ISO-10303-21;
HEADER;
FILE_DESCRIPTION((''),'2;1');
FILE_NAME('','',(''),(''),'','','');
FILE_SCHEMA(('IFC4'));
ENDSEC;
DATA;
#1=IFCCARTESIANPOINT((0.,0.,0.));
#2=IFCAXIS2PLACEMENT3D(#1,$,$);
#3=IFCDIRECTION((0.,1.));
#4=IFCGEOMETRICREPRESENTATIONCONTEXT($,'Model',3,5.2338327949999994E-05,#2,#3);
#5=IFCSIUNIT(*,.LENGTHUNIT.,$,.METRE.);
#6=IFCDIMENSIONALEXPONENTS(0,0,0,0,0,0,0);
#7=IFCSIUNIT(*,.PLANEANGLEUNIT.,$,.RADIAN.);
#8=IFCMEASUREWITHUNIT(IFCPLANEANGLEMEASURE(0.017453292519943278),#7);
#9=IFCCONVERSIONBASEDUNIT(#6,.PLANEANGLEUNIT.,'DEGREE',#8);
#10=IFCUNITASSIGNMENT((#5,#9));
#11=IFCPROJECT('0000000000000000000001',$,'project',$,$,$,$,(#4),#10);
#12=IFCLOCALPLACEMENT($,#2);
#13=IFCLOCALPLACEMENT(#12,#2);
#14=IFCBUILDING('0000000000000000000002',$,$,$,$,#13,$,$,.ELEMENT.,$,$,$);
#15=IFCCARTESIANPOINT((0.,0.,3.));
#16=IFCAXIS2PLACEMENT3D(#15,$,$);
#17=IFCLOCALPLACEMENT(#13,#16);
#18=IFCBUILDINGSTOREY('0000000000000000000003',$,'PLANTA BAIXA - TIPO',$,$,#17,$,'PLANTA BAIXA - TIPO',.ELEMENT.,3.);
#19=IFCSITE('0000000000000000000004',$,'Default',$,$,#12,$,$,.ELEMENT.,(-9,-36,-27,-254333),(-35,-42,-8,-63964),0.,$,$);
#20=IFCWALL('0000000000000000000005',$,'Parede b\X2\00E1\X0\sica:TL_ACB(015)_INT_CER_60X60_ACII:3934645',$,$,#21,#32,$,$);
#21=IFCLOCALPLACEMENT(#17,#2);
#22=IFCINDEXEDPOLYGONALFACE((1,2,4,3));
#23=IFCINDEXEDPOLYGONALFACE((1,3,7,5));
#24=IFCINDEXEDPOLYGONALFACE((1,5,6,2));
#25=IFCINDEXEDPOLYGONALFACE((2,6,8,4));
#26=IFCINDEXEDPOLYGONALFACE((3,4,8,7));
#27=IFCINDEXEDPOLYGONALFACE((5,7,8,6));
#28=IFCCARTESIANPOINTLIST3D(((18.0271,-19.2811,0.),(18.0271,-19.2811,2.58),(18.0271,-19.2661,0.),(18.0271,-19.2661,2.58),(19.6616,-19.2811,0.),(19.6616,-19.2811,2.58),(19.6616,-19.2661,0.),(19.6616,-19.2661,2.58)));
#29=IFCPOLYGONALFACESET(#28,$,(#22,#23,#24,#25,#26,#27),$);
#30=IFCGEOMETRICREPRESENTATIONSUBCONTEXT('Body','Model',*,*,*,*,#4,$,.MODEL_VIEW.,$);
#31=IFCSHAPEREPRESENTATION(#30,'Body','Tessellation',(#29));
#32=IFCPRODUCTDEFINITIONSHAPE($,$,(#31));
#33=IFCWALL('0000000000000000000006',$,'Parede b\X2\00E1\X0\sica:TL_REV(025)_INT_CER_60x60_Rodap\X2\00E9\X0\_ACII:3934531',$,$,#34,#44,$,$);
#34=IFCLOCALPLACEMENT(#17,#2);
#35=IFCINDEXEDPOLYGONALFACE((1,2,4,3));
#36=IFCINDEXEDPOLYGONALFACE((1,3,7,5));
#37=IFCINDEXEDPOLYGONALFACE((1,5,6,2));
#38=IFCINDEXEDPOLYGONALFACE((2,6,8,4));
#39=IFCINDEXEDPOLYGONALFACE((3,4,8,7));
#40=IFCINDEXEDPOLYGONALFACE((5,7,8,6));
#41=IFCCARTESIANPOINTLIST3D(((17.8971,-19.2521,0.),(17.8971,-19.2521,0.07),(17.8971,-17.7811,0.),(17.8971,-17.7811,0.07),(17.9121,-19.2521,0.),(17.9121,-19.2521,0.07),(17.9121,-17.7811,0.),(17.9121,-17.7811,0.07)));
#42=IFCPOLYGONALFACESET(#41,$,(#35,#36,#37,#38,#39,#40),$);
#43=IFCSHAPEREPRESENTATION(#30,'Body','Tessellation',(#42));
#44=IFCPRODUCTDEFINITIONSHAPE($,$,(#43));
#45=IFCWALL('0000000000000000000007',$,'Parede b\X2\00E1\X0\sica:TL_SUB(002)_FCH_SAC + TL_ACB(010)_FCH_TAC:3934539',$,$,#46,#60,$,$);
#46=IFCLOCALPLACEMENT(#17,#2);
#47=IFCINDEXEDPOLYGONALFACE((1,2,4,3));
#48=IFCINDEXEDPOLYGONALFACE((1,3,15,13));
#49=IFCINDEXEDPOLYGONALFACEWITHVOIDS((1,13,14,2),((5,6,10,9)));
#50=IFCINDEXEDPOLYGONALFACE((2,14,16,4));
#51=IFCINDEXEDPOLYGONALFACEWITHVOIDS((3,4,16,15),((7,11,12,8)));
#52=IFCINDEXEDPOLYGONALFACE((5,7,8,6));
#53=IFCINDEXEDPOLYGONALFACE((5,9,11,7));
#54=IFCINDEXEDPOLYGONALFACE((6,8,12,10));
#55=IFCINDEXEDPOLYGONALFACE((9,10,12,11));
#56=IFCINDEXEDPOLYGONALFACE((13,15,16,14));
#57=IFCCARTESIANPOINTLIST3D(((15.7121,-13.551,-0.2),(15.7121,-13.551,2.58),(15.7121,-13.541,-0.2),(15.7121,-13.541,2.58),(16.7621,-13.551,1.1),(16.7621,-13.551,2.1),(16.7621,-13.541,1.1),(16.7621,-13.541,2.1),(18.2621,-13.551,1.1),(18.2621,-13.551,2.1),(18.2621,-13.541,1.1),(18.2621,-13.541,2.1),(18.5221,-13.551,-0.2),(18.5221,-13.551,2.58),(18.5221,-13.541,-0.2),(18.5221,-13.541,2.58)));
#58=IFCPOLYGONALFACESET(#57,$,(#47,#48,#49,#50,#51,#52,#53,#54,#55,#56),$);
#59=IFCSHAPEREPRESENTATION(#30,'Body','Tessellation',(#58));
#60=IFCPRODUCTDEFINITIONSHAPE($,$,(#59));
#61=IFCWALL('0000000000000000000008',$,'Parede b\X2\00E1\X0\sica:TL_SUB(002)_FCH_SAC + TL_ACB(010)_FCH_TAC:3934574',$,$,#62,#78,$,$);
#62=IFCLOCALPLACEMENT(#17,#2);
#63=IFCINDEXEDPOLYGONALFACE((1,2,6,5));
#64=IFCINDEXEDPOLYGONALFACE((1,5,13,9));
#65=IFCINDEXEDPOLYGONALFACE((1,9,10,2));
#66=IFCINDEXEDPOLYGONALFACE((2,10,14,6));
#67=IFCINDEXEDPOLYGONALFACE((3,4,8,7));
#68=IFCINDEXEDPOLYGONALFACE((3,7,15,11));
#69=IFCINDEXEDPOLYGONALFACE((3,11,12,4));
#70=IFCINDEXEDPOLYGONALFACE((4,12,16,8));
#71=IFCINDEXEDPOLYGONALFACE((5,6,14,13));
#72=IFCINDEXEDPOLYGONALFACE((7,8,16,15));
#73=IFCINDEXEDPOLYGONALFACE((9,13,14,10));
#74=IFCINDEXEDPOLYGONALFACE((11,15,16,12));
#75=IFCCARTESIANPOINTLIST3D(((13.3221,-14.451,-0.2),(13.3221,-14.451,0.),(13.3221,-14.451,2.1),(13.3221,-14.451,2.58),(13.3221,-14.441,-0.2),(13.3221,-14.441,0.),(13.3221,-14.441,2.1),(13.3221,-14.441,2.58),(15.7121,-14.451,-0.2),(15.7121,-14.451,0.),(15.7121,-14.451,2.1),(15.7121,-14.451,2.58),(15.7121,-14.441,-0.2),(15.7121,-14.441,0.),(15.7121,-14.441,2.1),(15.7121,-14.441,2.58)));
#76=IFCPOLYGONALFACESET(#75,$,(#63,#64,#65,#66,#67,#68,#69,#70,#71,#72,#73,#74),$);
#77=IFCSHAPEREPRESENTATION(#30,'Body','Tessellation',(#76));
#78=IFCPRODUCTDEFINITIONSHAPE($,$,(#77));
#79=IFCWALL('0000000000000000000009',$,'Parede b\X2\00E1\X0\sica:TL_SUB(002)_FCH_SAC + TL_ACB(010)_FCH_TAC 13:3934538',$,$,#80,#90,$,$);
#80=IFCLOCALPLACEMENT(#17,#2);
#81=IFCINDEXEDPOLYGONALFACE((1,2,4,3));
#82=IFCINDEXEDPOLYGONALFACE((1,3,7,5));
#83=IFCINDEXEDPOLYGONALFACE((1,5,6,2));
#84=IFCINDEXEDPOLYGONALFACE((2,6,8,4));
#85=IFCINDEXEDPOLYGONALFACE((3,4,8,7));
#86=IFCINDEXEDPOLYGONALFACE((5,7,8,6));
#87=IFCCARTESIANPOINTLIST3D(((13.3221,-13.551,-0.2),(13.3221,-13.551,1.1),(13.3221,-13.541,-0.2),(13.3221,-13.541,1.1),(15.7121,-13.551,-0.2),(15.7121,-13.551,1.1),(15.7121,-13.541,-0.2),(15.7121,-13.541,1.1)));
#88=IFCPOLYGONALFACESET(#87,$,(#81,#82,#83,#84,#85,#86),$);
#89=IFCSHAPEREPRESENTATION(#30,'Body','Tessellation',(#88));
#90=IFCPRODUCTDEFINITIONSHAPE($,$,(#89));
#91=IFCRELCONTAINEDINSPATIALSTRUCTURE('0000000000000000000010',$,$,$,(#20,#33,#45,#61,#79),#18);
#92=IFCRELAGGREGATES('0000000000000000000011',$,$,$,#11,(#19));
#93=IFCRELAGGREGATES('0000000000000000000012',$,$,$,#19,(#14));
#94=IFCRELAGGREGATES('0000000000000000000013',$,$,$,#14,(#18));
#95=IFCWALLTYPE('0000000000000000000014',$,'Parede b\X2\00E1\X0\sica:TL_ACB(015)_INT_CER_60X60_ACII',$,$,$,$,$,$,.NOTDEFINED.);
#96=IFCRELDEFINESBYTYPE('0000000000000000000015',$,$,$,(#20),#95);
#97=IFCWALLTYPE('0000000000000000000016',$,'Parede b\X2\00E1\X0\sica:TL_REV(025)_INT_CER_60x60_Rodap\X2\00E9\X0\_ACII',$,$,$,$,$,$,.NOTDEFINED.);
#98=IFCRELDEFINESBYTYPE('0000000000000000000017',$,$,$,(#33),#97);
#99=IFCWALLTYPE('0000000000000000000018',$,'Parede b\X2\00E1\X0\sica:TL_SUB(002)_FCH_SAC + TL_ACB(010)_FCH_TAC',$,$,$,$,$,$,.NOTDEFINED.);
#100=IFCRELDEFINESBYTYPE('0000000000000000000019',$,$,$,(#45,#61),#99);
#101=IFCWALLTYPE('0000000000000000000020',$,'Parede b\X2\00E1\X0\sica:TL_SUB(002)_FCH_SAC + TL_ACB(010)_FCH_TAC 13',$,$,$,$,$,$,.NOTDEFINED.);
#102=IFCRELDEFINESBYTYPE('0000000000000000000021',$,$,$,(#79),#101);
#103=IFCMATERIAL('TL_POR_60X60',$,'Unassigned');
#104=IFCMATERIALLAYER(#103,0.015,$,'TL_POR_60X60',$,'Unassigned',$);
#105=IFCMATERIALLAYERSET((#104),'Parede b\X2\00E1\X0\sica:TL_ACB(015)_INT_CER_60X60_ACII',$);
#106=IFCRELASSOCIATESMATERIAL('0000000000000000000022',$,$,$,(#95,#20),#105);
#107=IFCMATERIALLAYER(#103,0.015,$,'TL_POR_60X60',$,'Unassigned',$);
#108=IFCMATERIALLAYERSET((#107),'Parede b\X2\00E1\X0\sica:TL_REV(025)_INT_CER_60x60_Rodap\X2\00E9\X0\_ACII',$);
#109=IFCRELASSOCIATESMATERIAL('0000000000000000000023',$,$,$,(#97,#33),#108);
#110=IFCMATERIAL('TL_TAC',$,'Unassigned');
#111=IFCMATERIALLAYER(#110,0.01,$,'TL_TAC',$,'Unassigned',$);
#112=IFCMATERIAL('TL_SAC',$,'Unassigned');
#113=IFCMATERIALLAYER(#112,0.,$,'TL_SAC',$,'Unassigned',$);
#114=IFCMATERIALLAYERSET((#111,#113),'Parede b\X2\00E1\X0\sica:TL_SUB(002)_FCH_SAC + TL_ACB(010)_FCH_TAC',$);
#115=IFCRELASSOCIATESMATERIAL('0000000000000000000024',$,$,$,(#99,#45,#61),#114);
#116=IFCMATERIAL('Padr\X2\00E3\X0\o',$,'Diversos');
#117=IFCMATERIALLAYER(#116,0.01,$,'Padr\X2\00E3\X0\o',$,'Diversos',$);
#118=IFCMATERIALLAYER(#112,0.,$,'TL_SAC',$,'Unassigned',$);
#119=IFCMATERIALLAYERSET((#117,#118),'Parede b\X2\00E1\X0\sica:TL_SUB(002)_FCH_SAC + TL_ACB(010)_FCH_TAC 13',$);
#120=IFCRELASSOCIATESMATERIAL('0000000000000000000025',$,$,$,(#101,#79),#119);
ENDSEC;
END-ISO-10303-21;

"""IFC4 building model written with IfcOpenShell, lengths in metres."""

from ifc_helpers import new_model, entity, si_unit, converted_unit, direction, frame, frame_2d, origin, place, context, subcontext, project, spatial, rectangle, extrude, material, layer, layer_set, layer_usage, type_object, element, save


model = new_model("IFC4")

# Units and contexts
model_context = context("Model", 3, precision=5.2338327949999994e-05, world=origin(), true_north=direction((0.0, 1.0)))
body_context = subcontext(model_context, "Body", "Model", "MODEL_VIEW")
ifc_project = project(units=[si_unit("LENGTHUNIT", "METRE"), converted_unit("PLANEANGLEUNIT", "DEGREE", entity("IfcPlaneAngleMeasure", 0.017453292519943278), si_unit("PLANEANGLEUNIT", "RADIAN"), dimensions=[0, 0, 0, 0, 0, 0, 0])], contexts=[model_context])

# Site, building, storey
site_placement = place(None, frame((0.0, 0.0, 0.0)))
site = spatial("IfcSite", under=ifc_project, at=site_placement, Name="Default", CompositionType="ELEMENT", RefLatitude=(-9, -36, -27, -254333), RefLongitude=(-35, -42, -8, -63964), RefElevation=0.0)
building_placement = place(site_placement, origin())
building = spatial("IfcBuilding", under=site, at=building_placement, CompositionType="ELEMENT")
storey_placement = place(building_placement, frame((0.0, 0.0, 3.0)))
storey = spatial("IfcBuildingStorey", under=building, at=storey_placement, Name="PLANTA BAIXA - TIPO", LongName="PLANTA BAIXA - TIPO", CompositionType="ELEMENT", Elevation=3.0)

# Shared definitions
ifc_material_1 = material(Name="TL_SAC", Category="Unassigned")

# Walls
ifc_material_2 = material(Name="TL_POR_60X60", Category="Unassigned")
ifc_layer_1 = layer(ifc_material_2, 0.015, Name="TL_POR_60X60", Category="Unassigned")
ifc_layer_set_1 = layer_set([ifc_layer_1], Name="Parede básica:TL_ACB(015)_INT_CER_60X60_ACII")
wall_type_1 = type_object("IfcWallType", Name="Parede básica:TL_ACB(015)_INT_CER_60X60_ACII", PredefinedType="NOTDEFINED", material=ifc_layer_set_1)
ifc_layer_usage_1 = layer_usage(ifc_layer_set_1, "AXIS2", "NEGATIVE", 0.0075)
wall_1_placement = place(storey_placement, frame((18.0271, -19.2736, 0.0)))
element("IfcWall", 1, at=wall_1_placement, inside=storey, type_object=wall_type_1, material=ifc_layer_usage_1, Name="Parede básica:TL_ACB(015)_INT_CER_60X60_ACII:3934645", context=body_context, shape_type="SweptSolid", body=[
    extrude(rectangle(XDim=1.6345, YDim=0.015, at=frame_2d((0.8172, 0.0), x_axis=(-1.0, 0.0))), origin(), (0.0, 0.0, 1.0), 2.58),
])
ifc_layer_2 = layer(ifc_material_2, 0.015, Name="TL_POR_60X60", Category="Unassigned")
ifc_layer_set_2 = layer_set([ifc_layer_2], Name="Parede básica:TL_REV(025)_INT_CER_60x60_Rodapé_ACII")
ifc_layer_usage_2 = layer_usage(ifc_layer_set_2, "AXIS2", "NEGATIVE", 0.0075)
wall_type_2 = type_object("IfcWallType", Name="Parede básica:TL_REV(025)_INT_CER_60x60_Rodapé_ACII", PredefinedType="NOTDEFINED", material=ifc_layer_set_2)
wall_2_placement = place(storey_placement, frame((17.9046, -19.2521, 0.0), z_axis=(0.0, 0.0, 1.0), x_axis=(0.0, 1.0, 0.0)))
element("IfcWall", 2, at=wall_2_placement, inside=storey, type_object=wall_type_2, material=ifc_layer_usage_2, Name="Parede básica:TL_REV(025)_INT_CER_60x60_Rodapé_ACII:3934531", context=body_context, shape_type="SweptSolid", body=[
    extrude(rectangle(XDim=1.471, YDim=0.015, at=frame_2d((0.7355, 0.0), x_axis=(-1.0, 0.0))), origin(), (0.0, 0.0, 1.0), 0.07),
])

# Walls, openings
ifc_material_3 = material(Name="TL_TAC", Category="Unassigned")
ifc_layer_3 = layer(ifc_material_3, 0.01, Name="TL_TAC", Category="Unassigned")
ifc_layer_4 = layer(ifc_material_1, 0.0, Name="TL_SAC", Category="Unassigned")
ifc_layer_set_3 = layer_set([ifc_layer_3, ifc_layer_4], Name="Parede básica:TL_SUB(002)_FCH_SAC + TL_ACB(010)_FCH_TAC")
ifc_layer_usage_3 = layer_usage(ifc_layer_set_3, "AXIS2", "NEGATIVE", 0.005)
wall_type_3 = type_object("IfcWallType", Name="Parede básica:TL_SUB(002)_FCH_SAC + TL_ACB(010)_FCH_TAC", PredefinedType="NOTDEFINED", material=ifc_layer_set_3)
wall_3_placement = place(storey_placement, frame((15.7121, -13.546, -0.2)))
wall_3 = element("IfcWall", 3, at=wall_3_placement, inside=storey, type_object=wall_type_3, material=ifc_layer_usage_3, Name="Parede básica:TL_SUB(002)_FCH_SAC + TL_ACB(010)_FCH_TAC:3934539", context=body_context, shape_type="SweptSolid", body=[
    extrude(rectangle(XDim=2.81, YDim=0.01, at=frame_2d((1.405, 0.0), x_axis=(-1.0, 0.0))), origin(), (0.0, 0.0, 1.0), 2.78),
])
opening_1_placement = place(wall_3_placement, frame((-15.7121, 13.546, 1.3)))
element("IfcOpeningElement", 4, at=opening_1_placement, cuts=wall_3, PredefinedType="OPENING", context=body_context, shape_type="SweptSolid", body=[
    extrude(rectangle(XDim=1.0, YDim=1.5, at=frame_2d((0.0, 0.0), x_axis=(0.0, 1.0))), frame((17.5121, -15.175, 0.5), z_axis=(0.0, 1.0, 0.0), x_axis=(1.0, 0.0, 0.0)), (0.0, 0.0, 1.0), 3.048),
])
ifc_layer_usage_4 = layer_usage(ifc_layer_set_3, "AXIS2", "NEGATIVE", 0.005)
wall_4_placement = place(storey_placement, frame((13.3221, -14.446, -0.2)))
wall_4 = element("IfcWall", 5, at=wall_4_placement, inside=storey, type_object=wall_type_3, material=ifc_layer_usage_4, Name="Parede básica:TL_SUB(002)_FCH_SAC + TL_ACB(010)_FCH_TAC:3934574", context=body_context, shape_type="SweptSolid", body=[
    extrude(rectangle(XDim=2.39, YDim=0.01, at=frame_2d((1.195, 0.0), x_axis=(-1.0, 0.0))), origin(), (0.0, 0.0, 1.0), 2.78),
])
opening_2_placement = place(wall_4_placement, frame((-13.3221, 14.446, 0.2)))
element("IfcOpeningElement", 6, at=opening_2_placement, cuts=wall_4, PredefinedType="OPENING", context=body_context, shape_type="SweptSolid", body=[
    extrude(rectangle(XDim=2.1, YDim=2.4, at=frame_2d((0.0, 0.0), x_axis=(0.0, 1.0))), frame((14.5121, -15.975, 1.05), z_axis=(0.0, 1.0, 0.0), x_axis=(-1.0, 0.0, 0.0)), (0.0, 0.0, 1.0), 3.048),
])

# Wall
ifc_material_4 = material(Name="Padrão", Category="Diversos")
ifc_layer_5 = layer(ifc_material_4, 0.01, Name="Padrão", Category="Diversos")
ifc_layer_6 = layer(ifc_material_1, 0.0, Name="TL_SAC", Category="Unassigned")
ifc_layer_set_4 = layer_set([ifc_layer_5, ifc_layer_6], Name="Parede básica:TL_SUB(002)_FCH_SAC + TL_ACB(010)_FCH_TAC 13")
ifc_layer_usage_5 = layer_usage(ifc_layer_set_4, "AXIS2", "POSITIVE", -0.005)
wall_type_4 = type_object("IfcWallType", Name="Parede básica:TL_SUB(002)_FCH_SAC + TL_ACB(010)_FCH_TAC 13", PredefinedType="NOTDEFINED", material=ifc_layer_set_4)
wall_5_placement = place(storey_placement, frame((13.3221, -13.546, -0.2)))
element("IfcWall", 7, at=wall_5_placement, inside=storey, type_object=wall_type_4, material=ifc_layer_usage_5, Name="Parede básica:TL_SUB(002)_FCH_SAC + TL_ACB(010)_FCH_TAC 13:3934538", context=body_context, shape_type="SweptSolid", body=[
    extrude(rectangle(XDim=2.39, YDim=0.01, at=frame_2d((1.195, 0.0), x_axis=(-1.0, 0.0))), origin(), (0.0, 0.0, 1.0), 1.3),
])

save(model, "model.ifc")
